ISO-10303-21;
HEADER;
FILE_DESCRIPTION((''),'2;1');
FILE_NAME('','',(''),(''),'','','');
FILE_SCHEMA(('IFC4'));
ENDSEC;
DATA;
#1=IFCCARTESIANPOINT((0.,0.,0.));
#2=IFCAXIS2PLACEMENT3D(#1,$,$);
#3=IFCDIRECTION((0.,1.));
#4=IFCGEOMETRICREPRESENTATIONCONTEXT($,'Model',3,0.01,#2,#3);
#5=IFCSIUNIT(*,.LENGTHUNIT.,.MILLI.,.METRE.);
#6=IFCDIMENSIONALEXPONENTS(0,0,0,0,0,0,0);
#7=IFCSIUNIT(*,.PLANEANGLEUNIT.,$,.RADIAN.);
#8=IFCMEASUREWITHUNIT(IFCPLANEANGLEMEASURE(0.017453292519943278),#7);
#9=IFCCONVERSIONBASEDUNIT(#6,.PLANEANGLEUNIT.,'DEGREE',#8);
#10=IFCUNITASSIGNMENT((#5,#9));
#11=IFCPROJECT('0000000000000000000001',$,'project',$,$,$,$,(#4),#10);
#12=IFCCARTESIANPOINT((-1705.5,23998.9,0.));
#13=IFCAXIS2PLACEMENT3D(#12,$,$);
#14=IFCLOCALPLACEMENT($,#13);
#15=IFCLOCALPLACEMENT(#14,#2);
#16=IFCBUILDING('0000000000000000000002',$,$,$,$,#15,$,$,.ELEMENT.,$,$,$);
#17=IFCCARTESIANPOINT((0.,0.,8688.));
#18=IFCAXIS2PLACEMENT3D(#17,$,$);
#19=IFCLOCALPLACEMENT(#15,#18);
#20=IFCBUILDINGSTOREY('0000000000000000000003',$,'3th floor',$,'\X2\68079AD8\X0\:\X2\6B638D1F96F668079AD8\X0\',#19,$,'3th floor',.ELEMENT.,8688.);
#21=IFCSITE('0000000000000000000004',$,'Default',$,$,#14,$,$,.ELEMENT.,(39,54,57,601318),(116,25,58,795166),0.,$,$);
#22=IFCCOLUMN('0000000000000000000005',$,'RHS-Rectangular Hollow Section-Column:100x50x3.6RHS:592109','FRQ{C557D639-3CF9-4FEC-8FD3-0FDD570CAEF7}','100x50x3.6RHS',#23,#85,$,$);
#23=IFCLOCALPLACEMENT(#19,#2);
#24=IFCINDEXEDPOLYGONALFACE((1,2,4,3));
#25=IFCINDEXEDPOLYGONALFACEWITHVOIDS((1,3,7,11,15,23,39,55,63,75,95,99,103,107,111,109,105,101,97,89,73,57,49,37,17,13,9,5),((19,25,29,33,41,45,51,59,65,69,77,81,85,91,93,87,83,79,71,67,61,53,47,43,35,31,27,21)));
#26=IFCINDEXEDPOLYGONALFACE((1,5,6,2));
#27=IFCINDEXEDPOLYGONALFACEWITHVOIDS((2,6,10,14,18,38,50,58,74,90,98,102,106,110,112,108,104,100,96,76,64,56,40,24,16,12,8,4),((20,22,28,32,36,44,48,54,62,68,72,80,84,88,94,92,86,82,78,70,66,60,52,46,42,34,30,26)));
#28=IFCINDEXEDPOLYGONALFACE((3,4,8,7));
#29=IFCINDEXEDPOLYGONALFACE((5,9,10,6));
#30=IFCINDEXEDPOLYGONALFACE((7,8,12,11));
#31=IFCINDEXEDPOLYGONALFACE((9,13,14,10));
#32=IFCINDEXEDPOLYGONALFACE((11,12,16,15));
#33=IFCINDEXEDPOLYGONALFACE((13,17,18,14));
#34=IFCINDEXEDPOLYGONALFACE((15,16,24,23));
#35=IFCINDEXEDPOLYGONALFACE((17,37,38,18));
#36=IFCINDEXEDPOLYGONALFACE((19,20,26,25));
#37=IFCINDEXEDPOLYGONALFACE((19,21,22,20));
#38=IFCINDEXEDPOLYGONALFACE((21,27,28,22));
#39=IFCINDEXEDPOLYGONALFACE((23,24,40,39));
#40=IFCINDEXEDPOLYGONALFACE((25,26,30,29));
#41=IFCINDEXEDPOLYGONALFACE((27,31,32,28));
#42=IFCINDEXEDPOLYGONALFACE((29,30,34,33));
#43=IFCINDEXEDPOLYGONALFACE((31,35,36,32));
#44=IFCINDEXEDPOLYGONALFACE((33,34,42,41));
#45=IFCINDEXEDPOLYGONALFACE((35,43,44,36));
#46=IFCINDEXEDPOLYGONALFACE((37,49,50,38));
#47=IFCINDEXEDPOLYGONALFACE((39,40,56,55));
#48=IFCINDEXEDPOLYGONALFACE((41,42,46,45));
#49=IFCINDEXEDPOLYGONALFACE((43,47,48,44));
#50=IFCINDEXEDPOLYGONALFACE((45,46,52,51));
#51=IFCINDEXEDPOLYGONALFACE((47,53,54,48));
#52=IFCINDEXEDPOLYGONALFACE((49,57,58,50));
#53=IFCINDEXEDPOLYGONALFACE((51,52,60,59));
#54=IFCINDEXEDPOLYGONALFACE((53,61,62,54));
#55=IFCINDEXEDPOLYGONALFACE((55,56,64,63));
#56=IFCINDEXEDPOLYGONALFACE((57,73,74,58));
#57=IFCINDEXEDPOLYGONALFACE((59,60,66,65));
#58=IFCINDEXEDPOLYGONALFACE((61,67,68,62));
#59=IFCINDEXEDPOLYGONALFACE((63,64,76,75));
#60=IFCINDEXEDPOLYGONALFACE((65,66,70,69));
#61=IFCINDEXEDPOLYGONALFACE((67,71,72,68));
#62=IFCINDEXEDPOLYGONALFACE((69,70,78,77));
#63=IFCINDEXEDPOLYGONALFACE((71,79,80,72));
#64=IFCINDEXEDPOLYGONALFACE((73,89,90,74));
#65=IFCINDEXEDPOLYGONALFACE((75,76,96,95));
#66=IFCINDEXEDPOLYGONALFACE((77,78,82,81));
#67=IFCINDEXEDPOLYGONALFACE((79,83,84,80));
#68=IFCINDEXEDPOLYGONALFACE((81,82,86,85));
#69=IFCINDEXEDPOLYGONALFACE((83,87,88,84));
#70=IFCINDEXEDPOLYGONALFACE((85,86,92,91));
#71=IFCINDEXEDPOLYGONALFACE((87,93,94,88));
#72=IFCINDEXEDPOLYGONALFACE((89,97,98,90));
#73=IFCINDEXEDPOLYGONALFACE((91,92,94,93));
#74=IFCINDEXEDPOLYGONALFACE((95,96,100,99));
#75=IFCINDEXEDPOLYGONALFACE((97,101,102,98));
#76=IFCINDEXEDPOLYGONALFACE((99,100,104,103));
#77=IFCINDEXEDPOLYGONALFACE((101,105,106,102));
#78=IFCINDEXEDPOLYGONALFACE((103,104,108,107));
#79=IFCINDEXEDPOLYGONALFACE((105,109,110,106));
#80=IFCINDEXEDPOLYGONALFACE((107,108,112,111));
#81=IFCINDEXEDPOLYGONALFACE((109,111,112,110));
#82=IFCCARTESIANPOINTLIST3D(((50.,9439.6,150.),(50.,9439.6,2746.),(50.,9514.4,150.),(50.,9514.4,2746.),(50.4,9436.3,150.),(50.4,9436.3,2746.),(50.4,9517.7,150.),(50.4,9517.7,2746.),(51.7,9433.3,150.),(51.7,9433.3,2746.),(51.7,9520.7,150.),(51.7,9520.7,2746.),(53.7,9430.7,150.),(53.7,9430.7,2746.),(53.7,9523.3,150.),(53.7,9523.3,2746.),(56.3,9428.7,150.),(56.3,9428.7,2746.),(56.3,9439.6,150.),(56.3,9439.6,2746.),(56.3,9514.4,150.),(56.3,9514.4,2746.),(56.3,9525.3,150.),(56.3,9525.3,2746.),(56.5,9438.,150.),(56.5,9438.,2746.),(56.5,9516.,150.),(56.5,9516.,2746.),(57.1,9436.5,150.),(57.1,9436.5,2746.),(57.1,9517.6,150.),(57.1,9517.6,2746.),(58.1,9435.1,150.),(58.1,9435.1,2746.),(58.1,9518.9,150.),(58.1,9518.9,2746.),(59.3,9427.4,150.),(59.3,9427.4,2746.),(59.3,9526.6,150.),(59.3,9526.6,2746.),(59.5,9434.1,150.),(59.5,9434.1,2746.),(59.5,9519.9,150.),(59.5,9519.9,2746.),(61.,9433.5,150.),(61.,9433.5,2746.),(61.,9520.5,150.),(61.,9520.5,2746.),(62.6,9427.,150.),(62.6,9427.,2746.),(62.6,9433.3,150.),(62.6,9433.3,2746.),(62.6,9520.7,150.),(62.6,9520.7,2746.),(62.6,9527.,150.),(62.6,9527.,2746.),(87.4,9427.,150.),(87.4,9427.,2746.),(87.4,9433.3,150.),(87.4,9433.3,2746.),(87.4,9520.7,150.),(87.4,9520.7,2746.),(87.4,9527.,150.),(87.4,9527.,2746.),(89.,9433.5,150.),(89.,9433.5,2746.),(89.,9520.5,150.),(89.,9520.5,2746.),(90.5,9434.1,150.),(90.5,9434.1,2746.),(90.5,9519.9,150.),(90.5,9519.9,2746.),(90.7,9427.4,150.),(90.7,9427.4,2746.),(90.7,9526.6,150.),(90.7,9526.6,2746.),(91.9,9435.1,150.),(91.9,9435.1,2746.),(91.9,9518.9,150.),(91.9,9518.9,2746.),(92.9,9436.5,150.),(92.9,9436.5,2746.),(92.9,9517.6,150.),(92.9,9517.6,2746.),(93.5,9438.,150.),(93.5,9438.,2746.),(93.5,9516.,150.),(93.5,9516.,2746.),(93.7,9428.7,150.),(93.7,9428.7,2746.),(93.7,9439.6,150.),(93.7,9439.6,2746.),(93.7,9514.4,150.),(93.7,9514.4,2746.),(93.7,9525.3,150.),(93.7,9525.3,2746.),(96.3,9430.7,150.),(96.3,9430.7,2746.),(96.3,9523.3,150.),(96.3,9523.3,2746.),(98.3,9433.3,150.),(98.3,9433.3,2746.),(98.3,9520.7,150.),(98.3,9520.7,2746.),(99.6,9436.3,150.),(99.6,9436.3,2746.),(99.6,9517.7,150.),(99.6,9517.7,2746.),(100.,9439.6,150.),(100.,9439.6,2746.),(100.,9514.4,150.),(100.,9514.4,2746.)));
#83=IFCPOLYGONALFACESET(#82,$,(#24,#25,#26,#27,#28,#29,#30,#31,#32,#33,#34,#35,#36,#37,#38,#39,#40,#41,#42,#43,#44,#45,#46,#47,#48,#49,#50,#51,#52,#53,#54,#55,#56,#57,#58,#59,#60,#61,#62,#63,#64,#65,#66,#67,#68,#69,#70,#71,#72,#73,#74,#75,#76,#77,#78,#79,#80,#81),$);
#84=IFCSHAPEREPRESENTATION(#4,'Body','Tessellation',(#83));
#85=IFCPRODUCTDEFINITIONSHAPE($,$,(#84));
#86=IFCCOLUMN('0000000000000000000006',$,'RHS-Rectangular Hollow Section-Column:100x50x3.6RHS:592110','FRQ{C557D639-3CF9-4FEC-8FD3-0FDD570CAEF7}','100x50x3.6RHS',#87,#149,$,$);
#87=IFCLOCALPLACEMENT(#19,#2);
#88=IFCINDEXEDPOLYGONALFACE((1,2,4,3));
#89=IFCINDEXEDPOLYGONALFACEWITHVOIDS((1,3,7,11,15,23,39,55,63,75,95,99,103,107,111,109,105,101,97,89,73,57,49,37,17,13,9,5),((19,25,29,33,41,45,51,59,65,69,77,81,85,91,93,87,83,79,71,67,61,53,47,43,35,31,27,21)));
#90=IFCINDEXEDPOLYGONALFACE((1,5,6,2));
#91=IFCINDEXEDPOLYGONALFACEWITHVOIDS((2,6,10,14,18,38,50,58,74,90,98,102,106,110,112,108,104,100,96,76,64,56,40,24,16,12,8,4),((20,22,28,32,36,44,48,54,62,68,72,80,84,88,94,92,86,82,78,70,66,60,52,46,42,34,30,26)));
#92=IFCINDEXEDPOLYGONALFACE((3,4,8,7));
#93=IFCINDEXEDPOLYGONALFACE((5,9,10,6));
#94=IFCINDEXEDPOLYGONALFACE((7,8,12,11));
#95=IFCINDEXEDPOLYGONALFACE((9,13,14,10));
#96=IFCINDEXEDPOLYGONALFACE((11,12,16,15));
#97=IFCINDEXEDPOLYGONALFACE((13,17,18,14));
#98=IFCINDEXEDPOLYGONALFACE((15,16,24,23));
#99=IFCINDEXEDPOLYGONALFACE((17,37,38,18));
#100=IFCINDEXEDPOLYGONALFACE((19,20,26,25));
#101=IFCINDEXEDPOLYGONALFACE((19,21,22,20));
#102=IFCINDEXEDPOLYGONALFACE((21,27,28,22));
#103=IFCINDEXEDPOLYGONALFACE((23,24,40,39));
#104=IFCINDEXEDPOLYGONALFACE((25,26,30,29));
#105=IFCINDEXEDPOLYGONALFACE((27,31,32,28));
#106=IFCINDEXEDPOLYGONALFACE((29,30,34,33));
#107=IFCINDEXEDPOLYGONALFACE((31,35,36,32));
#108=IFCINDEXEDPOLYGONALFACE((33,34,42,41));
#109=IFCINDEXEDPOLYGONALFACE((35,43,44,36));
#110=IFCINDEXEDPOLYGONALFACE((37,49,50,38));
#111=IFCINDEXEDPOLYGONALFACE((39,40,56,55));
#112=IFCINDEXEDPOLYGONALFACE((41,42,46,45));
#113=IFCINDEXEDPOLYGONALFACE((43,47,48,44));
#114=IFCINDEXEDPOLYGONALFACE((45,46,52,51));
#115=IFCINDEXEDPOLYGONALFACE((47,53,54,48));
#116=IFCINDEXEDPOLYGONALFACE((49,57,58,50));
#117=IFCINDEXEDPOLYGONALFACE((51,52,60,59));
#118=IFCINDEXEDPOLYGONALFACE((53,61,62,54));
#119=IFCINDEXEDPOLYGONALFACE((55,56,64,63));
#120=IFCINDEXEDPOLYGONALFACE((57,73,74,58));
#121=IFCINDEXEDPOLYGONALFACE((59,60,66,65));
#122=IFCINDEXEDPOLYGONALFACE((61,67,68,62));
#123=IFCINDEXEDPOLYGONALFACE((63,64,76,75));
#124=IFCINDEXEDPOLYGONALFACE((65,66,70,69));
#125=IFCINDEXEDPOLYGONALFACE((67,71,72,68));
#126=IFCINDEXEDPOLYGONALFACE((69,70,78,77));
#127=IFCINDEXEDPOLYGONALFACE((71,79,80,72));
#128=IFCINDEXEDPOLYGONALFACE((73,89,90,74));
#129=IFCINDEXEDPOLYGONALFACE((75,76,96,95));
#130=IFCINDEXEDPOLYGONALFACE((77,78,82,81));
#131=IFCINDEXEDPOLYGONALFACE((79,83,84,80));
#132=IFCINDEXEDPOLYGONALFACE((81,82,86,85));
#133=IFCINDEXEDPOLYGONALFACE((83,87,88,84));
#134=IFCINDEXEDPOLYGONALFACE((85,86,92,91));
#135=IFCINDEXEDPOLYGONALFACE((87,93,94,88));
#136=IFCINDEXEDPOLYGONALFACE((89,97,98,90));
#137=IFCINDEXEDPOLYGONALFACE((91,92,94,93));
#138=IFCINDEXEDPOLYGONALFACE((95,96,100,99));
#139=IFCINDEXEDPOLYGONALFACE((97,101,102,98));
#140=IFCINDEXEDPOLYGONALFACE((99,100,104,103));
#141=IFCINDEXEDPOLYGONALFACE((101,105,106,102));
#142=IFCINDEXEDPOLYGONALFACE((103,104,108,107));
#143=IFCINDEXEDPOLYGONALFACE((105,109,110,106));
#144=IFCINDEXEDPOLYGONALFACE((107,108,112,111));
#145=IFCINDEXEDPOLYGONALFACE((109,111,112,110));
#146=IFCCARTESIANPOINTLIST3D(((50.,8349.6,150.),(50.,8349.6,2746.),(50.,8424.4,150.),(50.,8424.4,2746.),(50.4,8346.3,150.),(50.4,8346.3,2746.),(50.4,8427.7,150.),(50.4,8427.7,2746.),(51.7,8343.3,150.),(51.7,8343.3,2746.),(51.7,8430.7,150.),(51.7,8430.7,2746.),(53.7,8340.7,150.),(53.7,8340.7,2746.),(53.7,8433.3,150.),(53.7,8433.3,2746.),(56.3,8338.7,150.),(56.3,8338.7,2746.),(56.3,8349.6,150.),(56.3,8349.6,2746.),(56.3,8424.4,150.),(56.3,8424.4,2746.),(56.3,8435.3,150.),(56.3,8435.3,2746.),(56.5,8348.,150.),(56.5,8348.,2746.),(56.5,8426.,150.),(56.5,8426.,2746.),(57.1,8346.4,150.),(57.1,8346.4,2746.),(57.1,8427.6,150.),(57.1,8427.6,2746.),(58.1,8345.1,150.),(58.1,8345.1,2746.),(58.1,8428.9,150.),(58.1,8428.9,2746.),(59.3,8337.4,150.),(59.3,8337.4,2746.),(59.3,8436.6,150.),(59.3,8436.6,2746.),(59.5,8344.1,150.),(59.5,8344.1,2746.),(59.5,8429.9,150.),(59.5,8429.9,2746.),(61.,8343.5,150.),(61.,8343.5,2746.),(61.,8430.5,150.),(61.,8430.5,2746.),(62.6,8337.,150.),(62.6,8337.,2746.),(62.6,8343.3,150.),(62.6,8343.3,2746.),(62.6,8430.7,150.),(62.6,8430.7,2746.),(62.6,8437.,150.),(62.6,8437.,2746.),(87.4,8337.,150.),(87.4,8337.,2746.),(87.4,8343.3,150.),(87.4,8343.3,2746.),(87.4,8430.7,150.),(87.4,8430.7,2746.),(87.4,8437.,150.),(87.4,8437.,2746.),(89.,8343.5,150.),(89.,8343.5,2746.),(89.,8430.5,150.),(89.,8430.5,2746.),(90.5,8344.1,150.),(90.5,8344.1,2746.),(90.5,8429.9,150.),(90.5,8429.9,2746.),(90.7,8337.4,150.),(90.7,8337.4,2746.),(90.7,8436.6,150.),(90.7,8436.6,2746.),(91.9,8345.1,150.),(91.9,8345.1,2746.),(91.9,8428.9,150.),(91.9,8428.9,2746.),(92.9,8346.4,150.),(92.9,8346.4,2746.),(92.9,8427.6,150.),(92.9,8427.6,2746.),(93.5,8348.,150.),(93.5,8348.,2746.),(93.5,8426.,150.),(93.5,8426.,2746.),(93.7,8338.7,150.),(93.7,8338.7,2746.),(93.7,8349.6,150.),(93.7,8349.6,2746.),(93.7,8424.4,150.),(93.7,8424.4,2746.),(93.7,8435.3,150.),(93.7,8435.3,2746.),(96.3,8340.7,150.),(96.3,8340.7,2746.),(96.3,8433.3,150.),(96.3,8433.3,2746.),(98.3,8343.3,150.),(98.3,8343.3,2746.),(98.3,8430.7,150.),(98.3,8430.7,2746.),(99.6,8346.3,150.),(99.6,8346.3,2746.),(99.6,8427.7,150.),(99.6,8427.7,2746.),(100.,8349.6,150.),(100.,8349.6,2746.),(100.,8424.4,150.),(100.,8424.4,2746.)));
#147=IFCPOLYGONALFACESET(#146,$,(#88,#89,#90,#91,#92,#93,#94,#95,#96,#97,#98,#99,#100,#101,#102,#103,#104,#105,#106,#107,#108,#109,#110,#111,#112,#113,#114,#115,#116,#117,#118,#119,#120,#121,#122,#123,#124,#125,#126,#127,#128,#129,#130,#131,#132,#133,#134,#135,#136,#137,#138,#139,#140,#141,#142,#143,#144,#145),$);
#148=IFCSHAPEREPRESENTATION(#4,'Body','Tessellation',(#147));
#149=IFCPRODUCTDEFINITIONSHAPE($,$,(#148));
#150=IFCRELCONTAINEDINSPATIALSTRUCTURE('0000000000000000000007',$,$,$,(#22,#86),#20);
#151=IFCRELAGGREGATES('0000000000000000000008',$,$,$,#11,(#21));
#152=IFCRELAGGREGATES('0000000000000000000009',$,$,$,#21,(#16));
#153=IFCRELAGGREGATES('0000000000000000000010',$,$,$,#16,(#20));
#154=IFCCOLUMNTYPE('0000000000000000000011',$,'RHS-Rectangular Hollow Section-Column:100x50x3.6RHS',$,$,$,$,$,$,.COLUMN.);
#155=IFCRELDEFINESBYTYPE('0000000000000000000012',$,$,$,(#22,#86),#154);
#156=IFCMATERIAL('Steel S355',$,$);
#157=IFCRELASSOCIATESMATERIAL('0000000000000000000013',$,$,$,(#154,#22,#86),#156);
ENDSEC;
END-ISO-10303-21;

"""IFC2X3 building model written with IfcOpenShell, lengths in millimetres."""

from ifc_helpers import new_model, entity, si_unit, converted_unit, point, direction, frame, frame_2d, origin, origin_2d, place, context, project, spatial, circle_curve, line_curve, trimmed, segment, composite_curve, hollow_rectangle, outline, extrude, clip, halfspace, material, type_object, element, save


model = new_model("IFC2X3")

# Units and contexts
model_context = context("Model", 3, precision=0.01, world=origin(), true_north=direction((0.0, 1.0)))
ifc_project = project(units=[si_unit("LENGTHUNIT", "METRE", prefix="MILLI"), converted_unit("PLANEANGLEUNIT", "DEGREE", entity("IfcPlaneAngleMeasure", 0.017453292519943278), si_unit("PLANEANGLEUNIT", "RADIAN"), dimensions=[0, 0, 0, 0, 0, 0, 0])], contexts=[model_context])

# Site, building, storey
site_placement = place(None, frame((-1705.5, 23998.9, 0.0)))
site = spatial("IfcSite", under=ifc_project, at=site_placement, Name="Default", CompositionType="ELEMENT", RefLatitude=(39, 54, 57, 601318), RefLongitude=(116, 25, 58, 795166), RefElevation=0.0)
building_placement = place(site_placement, origin())
building = spatial("IfcBuilding", under=site, at=building_placement, CompositionType="ELEMENT")
storey_placement = place(building_placement, frame((0.0, 0.0, 8688.0)))
storey = spatial("IfcBuildingStorey", under=building, at=storey_placement, Name="3th floor", ObjectType="标高:正负零标高", LongName="3th floor", CompositionType="ELEMENT", Elevation=8688.0)

# Columns, openings
ifc_material_1 = material(Name="Steel S355")
column_type_1 = type_object("IfcColumnType", Name="RHS-Rectangular Hollow Section-Column:100x50x3.6RHS", PredefinedType="COLUMN", material=ifc_material_1)
column_1_placement = place(storey_placement, frame((75.0, 9477.0, 2876.9)))
column_1 = element("IfcColumn", 1, at=column_1_placement, inside=storey, type_object=column_type_1, material=ifc_material_1, Name="RHS-Rectangular Hollow Section-Column:100x50x3.6RHS:592109", Description="FRQ{C557D639-3CF9-4FEC-8FD3-0FDD570CAEF7}", ObjectType="100x50x3.6RHS", context=model_context, shape_type="Clipping", body=[
    clip(clip(extrude(hollow_rectangle(XDim=50.0, YDim=100.0, WallThickness=6.3, InnerFilletRadius=6.3, OuterFilletRadius=12.6, at=origin_2d()), origin(), (0.0, 0.0, -1.0), 2782.8), halfspace(frame((-75.0, -9477.0, -55.9), z_axis=(0.0, 0.0, -1.0), x_axis=(-1.0, 0.0, 0.0)), True)), halfspace(frame((-75.0, -9477.0, -2726.9), z_axis=(0.0, 0.0, 1.0), x_axis=(1.0, 0.0, 0.0)), True)),
])
opening_1_placement = place(column_1_placement, frame((0.0, -150.1, -130.9), z_axis=(0.0, 1.0, 0.0), x_axis=(-1.0, 0.0, 0.0)))
element("IfcOpeningElement", 2, at=opening_1_placement, cuts=column_1, ObjectType="Opening", context=model_context, shape_type="SweptSolid", body=[
    extrude(outline(composite_curve([segment(trimmed(circle_curve(frame_2d((43.0, 32.0), x_axis=(1.0, 0.0)), 32.0), [point((43.0, 0.0))], [point((75.0, 32.0))], True, "CARTESIAN"), True, "CONTINUOUS"), segment(trimmed(line_curve((75.0, 32.0), (0.0, 1.0), 86.0), [point((75.0, 32.0))], [point((75.0, 118.0))], True, "CARTESIAN"), True, "CONTINUOUS"), segment(trimmed(circle_curve(frame_2d((43.0, 118.0), x_axis=(1.0, 0.0)), 32.0), [point((75.0, 118.0))], [point((43.0, 150.0))], True, "CARTESIAN"), True, "CONTINUOUS"), segment(trimmed(line_curve((43.0, 150.0), (-1.0, 0.0), 86.0), [point((43.0, 150.0))], [point((-43.0, 150.0))], True, "CARTESIAN"), True, "CONTINUOUS"), segment(trimmed(circle_curve(frame_2d((-43.0, 118.0), x_axis=(1.0, 0.0)), 32.0), [point((-43.0, 150.0))], [point((-75.0, 118.0))], True, "CARTESIAN"), True, "CONTINUOUS"), segment(trimmed(line_curve((-75.0, 118.0), (0.0, -1.0), 86.0), [point((-75.0, 118.0))], [point((-75.0, 32.0))], True, "CARTESIAN"), True, "CONTINUOUS"), segment(trimmed(circle_curve(frame_2d((-43.0, 32.0), x_axis=(1.0, 0.0)), 32.0), [point((-75.0, 32.0))], [point((-43.0, 0.0))], True, "CARTESIAN"), True, "CONTINUOUS"), segment(trimmed(line_curve((-43.0, 0.0), (1.0, 0.0), 86.0), [point((-43.0, 0.0))], [point((43.0, 0.0))], True, "CARTESIAN"), True, "CONTINUOUS")], self_intersect="UNKNOWN")), origin(), (0.0, 0.0, 1.0), 300.2),
])
column_2_placement = place(storey_placement, frame((75.0, 8387.0, 2876.9)))
column_2 = element("IfcColumn", 3, at=column_2_placement, inside=storey, type_object=column_type_1, material=ifc_material_1, Name="RHS-Rectangular Hollow Section-Column:100x50x3.6RHS:592110", Description="FRQ{C557D639-3CF9-4FEC-8FD3-0FDD570CAEF7}", ObjectType="100x50x3.6RHS", context=model_context, shape_type="Clipping", body=[
    clip(clip(extrude(hollow_rectangle(XDim=50.0, YDim=100.0, WallThickness=6.3, InnerFilletRadius=6.3, OuterFilletRadius=12.6, at=origin_2d()), origin(), (0.0, 0.0, -1.0), 2782.8), halfspace(frame((-75.0, -8387.0, -2726.9), z_axis=(0.0, 0.0, 1.0), x_axis=(1.0, 0.0, 0.0)), True)), halfspace(frame((-75.0, -8387.0, -55.9), z_axis=(0.0, 0.0, -1.0), x_axis=(-1.0, 0.0, 0.0)), True)),
])
opening_2_placement = place(column_2_placement, frame((0.0, -150.1, -130.9), z_axis=(0.0, 1.0, 0.0), x_axis=(-1.0, 0.0, 0.0)))
element("IfcOpeningElement", 4, at=opening_2_placement, cuts=column_2, ObjectType="Opening", context=model_context, shape_type="SweptSolid", body=[
    extrude(outline(composite_curve([segment(trimmed(circle_curve(frame_2d((43.0, 32.0), x_axis=(1.0, 0.0)), 32.0), [point((43.0, 0.0))], [point((75.0, 32.0))], True, "CARTESIAN"), True, "CONTINUOUS"), segment(trimmed(line_curve((75.0, 32.0), (0.0, 1.0), 86.0), [point((75.0, 32.0))], [point((75.0, 118.0))], True, "CARTESIAN"), True, "CONTINUOUS"), segment(trimmed(circle_curve(frame_2d((43.0, 118.0), x_axis=(1.0, 0.0)), 32.0), [point((75.0, 118.0))], [point((43.0, 150.0))], True, "CARTESIAN"), True, "CONTINUOUS"), segment(trimmed(line_curve((43.0, 150.0), (-1.0, 0.0), 86.0), [point((43.0, 150.0))], [point((-43.0, 150.0))], True, "CARTESIAN"), True, "CONTINUOUS"), segment(trimmed(circle_curve(frame_2d((-43.0, 118.0), x_axis=(1.0, 0.0)), 32.0), [point((-43.0, 150.0))], [point((-75.0, 118.0))], True, "CARTESIAN"), True, "CONTINUOUS"), segment(trimmed(line_curve((-75.0, 118.0), (0.0, -1.0), 86.0), [point((-75.0, 118.0))], [point((-75.0, 32.0))], True, "CARTESIAN"), True, "CONTINUOUS"), segment(trimmed(circle_curve(frame_2d((-43.0, 32.0), x_axis=(1.0, 0.0)), 32.0), [point((-75.0, 32.0))], [point((-43.0, 0.0))], True, "CARTESIAN"), True, "CONTINUOUS"), segment(trimmed(line_curve((-43.0, 0.0), (1.0, 0.0), 86.0), [point((-43.0, 0.0))], [point((43.0, 0.0))], True, "CARTESIAN"), True, "CONTINUOUS")], self_intersect="UNKNOWN")), origin(), (0.0, 0.0, 1.0), 300.2),
])

save(model, "model.ifc")
